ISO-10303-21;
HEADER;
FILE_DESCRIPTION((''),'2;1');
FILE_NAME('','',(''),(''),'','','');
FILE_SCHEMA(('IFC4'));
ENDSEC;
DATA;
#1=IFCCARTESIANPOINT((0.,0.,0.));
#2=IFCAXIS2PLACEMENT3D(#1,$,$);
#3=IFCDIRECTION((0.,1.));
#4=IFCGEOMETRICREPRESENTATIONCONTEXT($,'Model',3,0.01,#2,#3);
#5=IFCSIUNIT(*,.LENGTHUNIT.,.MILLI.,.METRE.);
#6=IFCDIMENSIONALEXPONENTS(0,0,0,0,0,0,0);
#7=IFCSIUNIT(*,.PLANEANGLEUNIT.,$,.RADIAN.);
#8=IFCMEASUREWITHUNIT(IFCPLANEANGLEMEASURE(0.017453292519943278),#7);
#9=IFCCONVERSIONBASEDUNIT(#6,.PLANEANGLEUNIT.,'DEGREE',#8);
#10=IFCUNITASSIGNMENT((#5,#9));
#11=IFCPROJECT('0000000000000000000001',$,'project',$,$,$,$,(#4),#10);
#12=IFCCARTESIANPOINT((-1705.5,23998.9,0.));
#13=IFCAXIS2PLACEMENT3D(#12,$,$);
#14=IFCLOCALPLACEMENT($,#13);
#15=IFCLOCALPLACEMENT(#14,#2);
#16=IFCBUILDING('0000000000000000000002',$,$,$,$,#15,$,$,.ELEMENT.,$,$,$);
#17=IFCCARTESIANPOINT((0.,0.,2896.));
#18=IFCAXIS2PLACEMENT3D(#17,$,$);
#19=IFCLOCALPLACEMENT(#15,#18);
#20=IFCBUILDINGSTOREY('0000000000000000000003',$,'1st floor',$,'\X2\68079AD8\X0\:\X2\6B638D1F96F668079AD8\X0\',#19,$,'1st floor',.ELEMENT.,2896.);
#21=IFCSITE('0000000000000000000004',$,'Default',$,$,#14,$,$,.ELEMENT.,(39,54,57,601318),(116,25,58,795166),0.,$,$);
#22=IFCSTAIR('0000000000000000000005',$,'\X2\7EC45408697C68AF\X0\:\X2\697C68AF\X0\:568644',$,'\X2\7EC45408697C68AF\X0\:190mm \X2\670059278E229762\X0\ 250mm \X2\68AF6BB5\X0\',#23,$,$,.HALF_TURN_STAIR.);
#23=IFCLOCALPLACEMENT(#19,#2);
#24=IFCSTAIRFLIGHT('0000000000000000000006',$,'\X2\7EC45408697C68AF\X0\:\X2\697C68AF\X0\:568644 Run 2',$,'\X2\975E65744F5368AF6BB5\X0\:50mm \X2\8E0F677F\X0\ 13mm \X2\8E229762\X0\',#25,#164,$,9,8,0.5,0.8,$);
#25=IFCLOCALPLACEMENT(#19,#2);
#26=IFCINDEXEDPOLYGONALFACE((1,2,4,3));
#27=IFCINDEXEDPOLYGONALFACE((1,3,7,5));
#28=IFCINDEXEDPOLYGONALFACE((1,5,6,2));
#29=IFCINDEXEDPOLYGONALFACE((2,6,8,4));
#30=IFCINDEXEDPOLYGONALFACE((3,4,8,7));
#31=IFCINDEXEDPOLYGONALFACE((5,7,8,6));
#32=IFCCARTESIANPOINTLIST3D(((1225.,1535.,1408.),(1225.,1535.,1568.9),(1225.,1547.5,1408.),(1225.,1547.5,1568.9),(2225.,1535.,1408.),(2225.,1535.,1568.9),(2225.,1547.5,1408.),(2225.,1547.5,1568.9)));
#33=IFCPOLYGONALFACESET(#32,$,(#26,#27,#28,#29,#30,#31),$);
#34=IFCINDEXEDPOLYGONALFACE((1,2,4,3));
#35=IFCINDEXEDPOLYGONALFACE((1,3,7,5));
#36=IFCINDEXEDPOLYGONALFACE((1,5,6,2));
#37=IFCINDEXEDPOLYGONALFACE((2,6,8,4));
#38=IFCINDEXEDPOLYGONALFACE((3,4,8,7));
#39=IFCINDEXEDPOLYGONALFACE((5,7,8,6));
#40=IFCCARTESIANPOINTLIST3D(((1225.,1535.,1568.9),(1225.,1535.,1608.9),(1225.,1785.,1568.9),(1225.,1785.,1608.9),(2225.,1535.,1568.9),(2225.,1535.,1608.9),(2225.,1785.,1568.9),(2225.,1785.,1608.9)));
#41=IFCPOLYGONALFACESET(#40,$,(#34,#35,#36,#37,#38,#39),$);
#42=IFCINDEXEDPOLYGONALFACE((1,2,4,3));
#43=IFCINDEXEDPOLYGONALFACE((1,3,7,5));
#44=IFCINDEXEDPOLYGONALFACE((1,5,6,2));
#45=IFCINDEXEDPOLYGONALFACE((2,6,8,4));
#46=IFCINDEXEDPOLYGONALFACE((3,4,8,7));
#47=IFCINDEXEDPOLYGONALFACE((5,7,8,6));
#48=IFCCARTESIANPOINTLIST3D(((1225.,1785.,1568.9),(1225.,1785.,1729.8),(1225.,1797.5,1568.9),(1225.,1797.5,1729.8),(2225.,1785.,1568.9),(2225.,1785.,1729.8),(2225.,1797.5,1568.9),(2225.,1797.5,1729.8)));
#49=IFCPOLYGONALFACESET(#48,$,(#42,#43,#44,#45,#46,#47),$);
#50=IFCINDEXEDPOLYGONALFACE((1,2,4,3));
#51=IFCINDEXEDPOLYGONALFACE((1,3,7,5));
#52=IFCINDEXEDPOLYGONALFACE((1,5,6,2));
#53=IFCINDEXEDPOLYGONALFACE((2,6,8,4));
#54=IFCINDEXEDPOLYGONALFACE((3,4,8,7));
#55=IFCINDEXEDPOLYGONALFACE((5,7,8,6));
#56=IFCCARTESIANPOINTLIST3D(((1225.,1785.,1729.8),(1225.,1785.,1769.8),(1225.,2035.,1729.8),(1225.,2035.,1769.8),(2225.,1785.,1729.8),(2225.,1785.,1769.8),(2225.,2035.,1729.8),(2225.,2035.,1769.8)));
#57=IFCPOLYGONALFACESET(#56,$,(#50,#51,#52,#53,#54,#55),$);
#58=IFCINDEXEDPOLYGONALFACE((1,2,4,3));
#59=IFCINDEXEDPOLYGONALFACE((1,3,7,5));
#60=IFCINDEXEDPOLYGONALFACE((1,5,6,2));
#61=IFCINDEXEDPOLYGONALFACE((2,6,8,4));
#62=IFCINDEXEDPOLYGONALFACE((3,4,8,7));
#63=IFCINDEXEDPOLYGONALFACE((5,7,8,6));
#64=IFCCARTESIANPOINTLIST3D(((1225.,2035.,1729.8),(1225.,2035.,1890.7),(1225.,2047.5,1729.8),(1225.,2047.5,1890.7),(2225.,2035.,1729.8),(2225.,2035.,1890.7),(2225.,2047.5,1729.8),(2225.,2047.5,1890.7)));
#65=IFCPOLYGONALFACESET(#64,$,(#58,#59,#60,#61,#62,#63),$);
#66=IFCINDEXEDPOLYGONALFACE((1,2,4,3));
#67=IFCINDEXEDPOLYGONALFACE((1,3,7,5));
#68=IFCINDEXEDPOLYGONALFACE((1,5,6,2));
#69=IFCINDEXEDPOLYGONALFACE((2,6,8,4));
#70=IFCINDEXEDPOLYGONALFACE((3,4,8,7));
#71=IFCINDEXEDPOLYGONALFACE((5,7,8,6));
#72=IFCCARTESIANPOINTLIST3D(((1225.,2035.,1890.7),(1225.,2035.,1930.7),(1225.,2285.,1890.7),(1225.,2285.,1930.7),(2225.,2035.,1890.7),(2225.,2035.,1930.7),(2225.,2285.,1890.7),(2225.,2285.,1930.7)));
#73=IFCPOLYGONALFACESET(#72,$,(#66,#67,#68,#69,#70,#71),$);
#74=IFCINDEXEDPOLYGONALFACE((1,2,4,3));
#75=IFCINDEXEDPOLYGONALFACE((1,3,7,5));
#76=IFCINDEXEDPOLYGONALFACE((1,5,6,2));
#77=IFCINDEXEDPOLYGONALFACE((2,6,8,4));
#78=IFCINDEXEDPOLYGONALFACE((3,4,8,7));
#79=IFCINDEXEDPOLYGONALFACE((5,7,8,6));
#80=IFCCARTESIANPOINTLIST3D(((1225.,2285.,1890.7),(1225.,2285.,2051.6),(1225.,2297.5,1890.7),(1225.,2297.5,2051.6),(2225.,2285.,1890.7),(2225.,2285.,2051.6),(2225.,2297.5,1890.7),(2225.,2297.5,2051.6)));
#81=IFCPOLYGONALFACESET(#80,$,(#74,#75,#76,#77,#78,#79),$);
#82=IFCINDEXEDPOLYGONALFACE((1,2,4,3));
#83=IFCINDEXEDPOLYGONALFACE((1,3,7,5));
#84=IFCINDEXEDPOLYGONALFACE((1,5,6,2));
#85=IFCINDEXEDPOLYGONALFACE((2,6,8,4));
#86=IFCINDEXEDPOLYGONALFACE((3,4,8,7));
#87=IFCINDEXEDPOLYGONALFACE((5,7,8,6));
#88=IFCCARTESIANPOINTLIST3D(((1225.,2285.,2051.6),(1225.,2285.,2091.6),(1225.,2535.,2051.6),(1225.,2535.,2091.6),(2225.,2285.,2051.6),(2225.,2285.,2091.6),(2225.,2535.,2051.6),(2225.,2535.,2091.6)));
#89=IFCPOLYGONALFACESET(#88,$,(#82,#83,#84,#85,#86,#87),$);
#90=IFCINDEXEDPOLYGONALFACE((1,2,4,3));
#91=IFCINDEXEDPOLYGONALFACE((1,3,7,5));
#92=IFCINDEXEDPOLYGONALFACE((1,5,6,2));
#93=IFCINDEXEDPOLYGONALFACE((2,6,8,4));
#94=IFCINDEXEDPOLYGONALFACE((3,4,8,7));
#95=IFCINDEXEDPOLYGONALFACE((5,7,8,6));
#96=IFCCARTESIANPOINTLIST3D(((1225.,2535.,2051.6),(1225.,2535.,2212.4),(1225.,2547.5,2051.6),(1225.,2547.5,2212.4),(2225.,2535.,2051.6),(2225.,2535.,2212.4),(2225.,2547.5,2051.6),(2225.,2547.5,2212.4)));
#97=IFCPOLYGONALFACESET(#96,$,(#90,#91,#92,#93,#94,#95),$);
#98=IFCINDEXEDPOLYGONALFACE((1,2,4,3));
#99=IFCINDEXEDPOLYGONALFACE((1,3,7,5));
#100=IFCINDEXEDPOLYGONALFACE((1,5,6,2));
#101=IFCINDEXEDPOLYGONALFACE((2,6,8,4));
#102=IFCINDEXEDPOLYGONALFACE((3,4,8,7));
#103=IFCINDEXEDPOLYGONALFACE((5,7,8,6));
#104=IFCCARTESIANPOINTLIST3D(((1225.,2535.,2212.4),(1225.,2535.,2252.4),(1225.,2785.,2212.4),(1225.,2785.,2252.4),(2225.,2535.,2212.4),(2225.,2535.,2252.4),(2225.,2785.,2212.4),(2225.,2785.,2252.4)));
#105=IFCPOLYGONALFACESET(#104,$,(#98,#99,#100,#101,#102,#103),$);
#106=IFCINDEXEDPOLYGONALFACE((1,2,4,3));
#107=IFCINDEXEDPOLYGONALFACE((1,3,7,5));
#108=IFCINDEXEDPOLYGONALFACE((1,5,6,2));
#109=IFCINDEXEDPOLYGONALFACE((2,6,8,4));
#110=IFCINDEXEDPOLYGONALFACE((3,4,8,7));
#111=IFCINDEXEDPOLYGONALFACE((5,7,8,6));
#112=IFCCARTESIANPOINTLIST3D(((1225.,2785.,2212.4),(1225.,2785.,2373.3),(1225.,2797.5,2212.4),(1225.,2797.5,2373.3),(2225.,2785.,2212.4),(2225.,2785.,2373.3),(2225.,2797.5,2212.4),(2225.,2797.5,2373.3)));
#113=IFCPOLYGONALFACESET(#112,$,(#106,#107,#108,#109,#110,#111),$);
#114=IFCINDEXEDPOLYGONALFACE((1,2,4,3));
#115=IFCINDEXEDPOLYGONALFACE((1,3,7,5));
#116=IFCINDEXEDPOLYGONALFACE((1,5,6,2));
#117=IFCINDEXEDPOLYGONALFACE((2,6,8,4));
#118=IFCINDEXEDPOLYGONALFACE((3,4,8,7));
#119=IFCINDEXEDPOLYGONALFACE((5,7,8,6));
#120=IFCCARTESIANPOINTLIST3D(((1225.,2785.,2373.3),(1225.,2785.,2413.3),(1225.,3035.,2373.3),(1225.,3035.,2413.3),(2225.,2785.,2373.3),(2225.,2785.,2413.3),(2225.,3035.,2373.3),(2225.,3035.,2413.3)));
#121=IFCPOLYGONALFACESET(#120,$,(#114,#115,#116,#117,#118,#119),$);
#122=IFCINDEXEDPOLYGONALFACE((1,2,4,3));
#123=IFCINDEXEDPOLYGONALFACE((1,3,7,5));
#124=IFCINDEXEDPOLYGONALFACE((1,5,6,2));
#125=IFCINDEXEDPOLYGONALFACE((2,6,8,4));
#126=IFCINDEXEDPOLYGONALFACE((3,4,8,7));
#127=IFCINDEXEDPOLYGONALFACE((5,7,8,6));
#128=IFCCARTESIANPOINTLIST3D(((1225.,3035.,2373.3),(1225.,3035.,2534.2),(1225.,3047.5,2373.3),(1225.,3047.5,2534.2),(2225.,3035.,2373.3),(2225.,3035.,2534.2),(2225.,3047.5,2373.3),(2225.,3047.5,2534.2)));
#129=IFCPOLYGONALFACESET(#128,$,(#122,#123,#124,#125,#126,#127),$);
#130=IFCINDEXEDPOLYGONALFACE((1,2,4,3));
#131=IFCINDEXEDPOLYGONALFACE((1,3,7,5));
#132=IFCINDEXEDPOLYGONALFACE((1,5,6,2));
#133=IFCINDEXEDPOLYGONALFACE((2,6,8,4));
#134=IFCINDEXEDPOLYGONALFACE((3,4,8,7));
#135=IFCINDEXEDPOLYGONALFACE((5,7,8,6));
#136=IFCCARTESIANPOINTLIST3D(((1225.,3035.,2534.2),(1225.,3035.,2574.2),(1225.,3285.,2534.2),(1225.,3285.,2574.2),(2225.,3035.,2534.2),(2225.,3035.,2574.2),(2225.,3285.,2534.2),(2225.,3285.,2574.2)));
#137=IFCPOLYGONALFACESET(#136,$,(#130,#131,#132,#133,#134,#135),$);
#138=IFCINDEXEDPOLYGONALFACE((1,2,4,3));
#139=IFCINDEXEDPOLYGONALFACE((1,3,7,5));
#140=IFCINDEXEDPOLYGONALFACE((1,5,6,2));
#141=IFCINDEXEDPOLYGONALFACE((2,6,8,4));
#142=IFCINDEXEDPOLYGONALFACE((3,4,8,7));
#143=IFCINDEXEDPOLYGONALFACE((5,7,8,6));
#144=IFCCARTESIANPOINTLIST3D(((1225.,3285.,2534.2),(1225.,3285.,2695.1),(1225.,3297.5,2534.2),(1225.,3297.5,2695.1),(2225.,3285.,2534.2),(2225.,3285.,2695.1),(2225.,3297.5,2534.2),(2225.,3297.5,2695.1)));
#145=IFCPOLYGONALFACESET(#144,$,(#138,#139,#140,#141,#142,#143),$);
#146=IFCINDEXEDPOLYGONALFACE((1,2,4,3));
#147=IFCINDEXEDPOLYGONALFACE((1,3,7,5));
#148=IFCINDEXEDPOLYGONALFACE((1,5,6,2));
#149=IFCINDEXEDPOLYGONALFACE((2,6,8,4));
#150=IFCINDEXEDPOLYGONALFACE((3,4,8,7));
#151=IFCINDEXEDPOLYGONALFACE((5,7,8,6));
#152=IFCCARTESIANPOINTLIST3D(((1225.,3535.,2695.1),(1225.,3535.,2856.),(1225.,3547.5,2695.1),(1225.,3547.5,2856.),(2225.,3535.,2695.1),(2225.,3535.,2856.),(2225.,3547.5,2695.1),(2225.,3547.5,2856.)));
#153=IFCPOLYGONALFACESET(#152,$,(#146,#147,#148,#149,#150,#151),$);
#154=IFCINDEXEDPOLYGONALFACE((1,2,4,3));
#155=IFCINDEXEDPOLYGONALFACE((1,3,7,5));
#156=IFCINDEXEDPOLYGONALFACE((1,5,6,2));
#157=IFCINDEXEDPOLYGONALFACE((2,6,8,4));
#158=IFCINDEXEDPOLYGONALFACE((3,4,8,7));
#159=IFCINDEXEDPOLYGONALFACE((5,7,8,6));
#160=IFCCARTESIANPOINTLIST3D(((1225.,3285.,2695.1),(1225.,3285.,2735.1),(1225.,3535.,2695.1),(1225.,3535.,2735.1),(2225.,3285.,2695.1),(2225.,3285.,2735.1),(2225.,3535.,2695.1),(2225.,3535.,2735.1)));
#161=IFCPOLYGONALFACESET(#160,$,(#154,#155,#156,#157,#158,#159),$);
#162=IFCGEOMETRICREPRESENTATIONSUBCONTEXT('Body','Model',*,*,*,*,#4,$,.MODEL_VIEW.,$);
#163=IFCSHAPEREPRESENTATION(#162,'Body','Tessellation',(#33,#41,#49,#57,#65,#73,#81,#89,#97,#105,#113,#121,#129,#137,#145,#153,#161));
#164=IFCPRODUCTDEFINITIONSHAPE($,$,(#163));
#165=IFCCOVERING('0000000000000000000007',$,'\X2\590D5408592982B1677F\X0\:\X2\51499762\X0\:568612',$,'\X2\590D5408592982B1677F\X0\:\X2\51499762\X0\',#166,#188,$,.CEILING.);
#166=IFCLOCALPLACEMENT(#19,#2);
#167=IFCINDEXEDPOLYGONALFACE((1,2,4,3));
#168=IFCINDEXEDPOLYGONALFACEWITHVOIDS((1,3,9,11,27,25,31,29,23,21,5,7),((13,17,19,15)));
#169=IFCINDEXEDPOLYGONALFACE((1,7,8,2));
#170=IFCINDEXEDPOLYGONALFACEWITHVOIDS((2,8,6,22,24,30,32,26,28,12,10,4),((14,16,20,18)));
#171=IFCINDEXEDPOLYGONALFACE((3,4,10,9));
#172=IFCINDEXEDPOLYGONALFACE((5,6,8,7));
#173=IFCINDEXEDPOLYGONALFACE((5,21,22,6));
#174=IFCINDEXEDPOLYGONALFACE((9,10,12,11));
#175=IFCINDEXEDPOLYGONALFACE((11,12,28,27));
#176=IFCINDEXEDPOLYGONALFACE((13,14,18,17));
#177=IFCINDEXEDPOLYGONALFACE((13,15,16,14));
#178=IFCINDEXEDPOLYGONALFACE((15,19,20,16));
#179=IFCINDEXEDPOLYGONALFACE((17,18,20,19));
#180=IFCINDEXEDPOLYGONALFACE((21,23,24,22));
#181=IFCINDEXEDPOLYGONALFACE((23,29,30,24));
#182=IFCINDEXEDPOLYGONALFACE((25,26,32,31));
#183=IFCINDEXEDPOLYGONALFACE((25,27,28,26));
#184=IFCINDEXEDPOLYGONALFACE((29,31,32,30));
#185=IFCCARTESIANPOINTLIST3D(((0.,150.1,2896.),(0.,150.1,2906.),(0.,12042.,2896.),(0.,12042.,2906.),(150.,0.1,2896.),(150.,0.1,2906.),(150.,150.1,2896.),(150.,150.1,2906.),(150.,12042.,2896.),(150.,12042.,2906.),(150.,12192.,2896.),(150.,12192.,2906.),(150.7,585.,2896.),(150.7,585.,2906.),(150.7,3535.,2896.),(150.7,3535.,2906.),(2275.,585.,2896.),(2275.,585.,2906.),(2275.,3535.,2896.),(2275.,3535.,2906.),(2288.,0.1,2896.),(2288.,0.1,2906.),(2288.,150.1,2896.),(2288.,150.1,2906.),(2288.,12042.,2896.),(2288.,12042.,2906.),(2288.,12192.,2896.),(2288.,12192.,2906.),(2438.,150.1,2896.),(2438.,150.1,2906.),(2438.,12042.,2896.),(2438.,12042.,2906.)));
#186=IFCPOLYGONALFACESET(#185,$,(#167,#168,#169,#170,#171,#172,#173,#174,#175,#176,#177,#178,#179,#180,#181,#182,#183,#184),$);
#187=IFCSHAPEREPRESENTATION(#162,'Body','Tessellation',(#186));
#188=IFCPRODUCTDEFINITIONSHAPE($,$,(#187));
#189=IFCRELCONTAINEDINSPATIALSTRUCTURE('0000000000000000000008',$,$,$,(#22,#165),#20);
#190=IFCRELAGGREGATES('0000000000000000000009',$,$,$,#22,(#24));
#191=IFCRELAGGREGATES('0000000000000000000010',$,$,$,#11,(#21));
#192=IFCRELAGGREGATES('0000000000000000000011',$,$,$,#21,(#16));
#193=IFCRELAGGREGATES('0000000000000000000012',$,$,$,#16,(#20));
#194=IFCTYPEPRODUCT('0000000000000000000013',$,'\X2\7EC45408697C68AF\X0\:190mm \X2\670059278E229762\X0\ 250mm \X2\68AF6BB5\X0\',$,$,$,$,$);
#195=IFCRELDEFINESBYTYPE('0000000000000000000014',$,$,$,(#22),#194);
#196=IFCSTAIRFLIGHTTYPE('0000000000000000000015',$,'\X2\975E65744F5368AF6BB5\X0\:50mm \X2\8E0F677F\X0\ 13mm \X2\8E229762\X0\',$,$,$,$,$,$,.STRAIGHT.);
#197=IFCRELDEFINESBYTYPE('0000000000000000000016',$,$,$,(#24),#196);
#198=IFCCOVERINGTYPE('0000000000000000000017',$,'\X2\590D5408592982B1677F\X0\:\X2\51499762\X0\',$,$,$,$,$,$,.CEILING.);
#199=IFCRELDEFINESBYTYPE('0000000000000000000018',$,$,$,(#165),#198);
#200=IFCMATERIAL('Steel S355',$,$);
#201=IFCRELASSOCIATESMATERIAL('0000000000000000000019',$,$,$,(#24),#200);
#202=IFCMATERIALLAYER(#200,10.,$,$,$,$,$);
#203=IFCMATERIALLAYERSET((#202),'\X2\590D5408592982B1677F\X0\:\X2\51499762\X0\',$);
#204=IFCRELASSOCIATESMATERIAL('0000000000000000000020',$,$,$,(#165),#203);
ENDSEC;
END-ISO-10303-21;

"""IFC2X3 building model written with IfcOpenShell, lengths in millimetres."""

from ifc_helpers import new_model, entity, si_unit, converted_unit, direction, frame, frame_2d, origin, origin_2d_with_axis, place, context, subcontext, project, spatial, polyline, rectangle, outline, extrude, material, layer, layer_set, layer_usage, type_object, element, aggregate, save


model = new_model("IFC2X3")

# Units and contexts
model_context = context("Model", 3, precision=0.01, world=origin(), true_north=direction((0.0, 1.0)))
body_context = subcontext(model_context, "Body", "Model", "MODEL_VIEW")
ifc_project = project(units=[si_unit("LENGTHUNIT", "METRE", prefix="MILLI"), converted_unit("PLANEANGLEUNIT", "DEGREE", entity("IfcPlaneAngleMeasure", 0.017453292519943278), si_unit("PLANEANGLEUNIT", "RADIAN"), dimensions=[0, 0, 0, 0, 0, 0, 0])], contexts=[model_context])

# Site, building, storey
site_placement = place(None, frame((-1705.5, 23998.9, 0.0)))
site = spatial("IfcSite", under=ifc_project, at=site_placement, Name="Default", CompositionType="ELEMENT", RefLatitude=(39, 54, 57, 601318), RefLongitude=(116, 25, 58, 795166), RefElevation=0.0)
building_placement = place(site_placement, origin())
building = spatial("IfcBuilding", under=site, at=building_placement, CompositionType="ELEMENT")
storey_placement = place(building_placement, frame((0.0, 0.0, 2896.0)))
storey = spatial("IfcBuildingStorey", under=building, at=storey_placement, Name="1st floor", ObjectType="标高:正负零标高", LongName="1st floor", CompositionType="ELEMENT", Elevation=2896.0)

# Stair
type_product = type_object("IfcTypeProduct", Name="组合楼梯:190mm 最大踢面 250mm 梯段")
stair_placement = place(storey_placement, origin())
stair = element("IfcStair", 1, at=stair_placement, inside=storey, type_object=type_product, Name="组合楼梯:楼梯:568644", ObjectType="组合楼梯:190mm 最大踢面 250mm 梯段", ShapeType="HALF_TURN_STAIR")
ifc_material_1 = material(Name="Steel S355")

# Stair flight
stair_flight_type = type_object("IfcStairFlightType", Name="非整体梯段:50mm 踏板 13mm 踢面", PredefinedType="STRAIGHT")
stair_flight_1_placement = place(stair_placement, origin())
stair_flight_1 = element("IfcStairFlight", 2, at=stair_flight_1_placement, type_object=stair_flight_type, material=ifc_material_1, Name="组合楼梯:楼梯:568644 Run 2", ObjectType="非整体梯段:50mm 踏板 13mm 踢面", NumberOfRiser=9, NumberOfTreads=8, RiserHeight=0.5, TreadLength=0.8, context=body_context, shape_type="SweptSolid", body=[
    extrude(rectangle(XDim=1000.0, YDim=12.5, at=origin_2d_with_axis()), frame((1725.0, 1541.2, 1408.0), z_axis=(0.0, 0.0, 1.0), x_axis=(-1.0, 0.0, 0.0)), (0.0, 0.0, 1.0), 160.9),
    extrude(rectangle(XDim=250.0, YDim=1000.0, at=frame_2d((0.0, 0.0), x_axis=(1.0, 0.0))), frame((1725.0, 1660.0, 1568.9), z_axis=(0.0, 0.0, 1.0), x_axis=(0.0, -1.0, 0.0)), (0.0, 0.0, 1.0), 40.0),
    extrude(rectangle(XDim=1000.0, YDim=12.5, at=origin_2d_with_axis()), frame((1725.0, 1791.2, 1568.9), z_axis=(0.0, 0.0, 1.0), x_axis=(-1.0, 0.0, 0.0)), (0.0, 0.0, 1.0), 160.9),
    extrude(rectangle(XDim=250.0, YDim=1000.0, at=frame_2d((0.0, 0.0), x_axis=(1.0, 0.0))), frame((1725.0, 1910.0, 1729.8), z_axis=(0.0, 0.0, 1.0), x_axis=(0.0, -1.0, 0.0)), (0.0, 0.0, 1.0), 40.0),
    extrude(rectangle(XDim=1000.0, YDim=12.5, at=origin_2d_with_axis()), frame((1725.0, 2041.2, 1729.8), z_axis=(0.0, 0.0, 1.0), x_axis=(-1.0, 0.0, 0.0)), (0.0, 0.0, 1.0), 160.9),
    extrude(rectangle(XDim=250.0, YDim=1000.0, at=frame_2d((0.0, 0.0), x_axis=(1.0, 0.0))), frame((1725.0, 2160.0, 1890.7), z_axis=(0.0, 0.0, 1.0), x_axis=(0.0, -1.0, 0.0)), (0.0, 0.0, 1.0), 40.0),
    extrude(rectangle(XDim=1000.0, YDim=12.5, at=origin_2d_with_axis()), frame((1725.0, 2291.2, 1890.7), z_axis=(0.0, 0.0, 1.0), x_axis=(-1.0, 0.0, 0.0)), (0.0, 0.0, 1.0), 160.9),
    extrude(rectangle(XDim=250.0, YDim=1000.0, at=frame_2d((0.0, 0.0), x_axis=(1.0, 0.0))), frame((1725.0, 2410.0, 2051.6), z_axis=(0.0, 0.0, 1.0), x_axis=(0.0, -1.0, 0.0)), (0.0, 0.0, 1.0), 40.0),
    extrude(rectangle(XDim=1000.0, YDim=12.5, at=origin_2d_with_axis()), frame((1725.0, 2541.2, 2051.6), z_axis=(0.0, 0.0, 1.0), x_axis=(-1.0, 0.0, 0.0)), (0.0, 0.0, 1.0), 160.9),
    extrude(rectangle(XDim=250.0, YDim=1000.0, at=origin_2d_with_axis()), frame((1725.0, 2660.0, 2212.4), z_axis=(0.0, 0.0, 1.0), x_axis=(0.0, -1.0, 0.0)), (0.0, 0.0, 1.0), 40.0),
    extrude(rectangle(XDim=1000.0, YDim=12.5, at=frame_2d((0.0, 0.0), x_axis=(1.0, 0.0))), frame((1725.0, 2791.2, 2212.4), z_axis=(0.0, 0.0, 1.0), x_axis=(-1.0, 0.0, 0.0)), (0.0, 0.0, 1.0), 160.9),
    extrude(rectangle(XDim=250.0, YDim=1000.0, at=origin_2d_with_axis()), frame((1725.0, 2910.0, 2373.3), z_axis=(0.0, 0.0, 1.0), x_axis=(0.0, -1.0, 0.0)), (0.0, 0.0, 1.0), 40.0),
    extrude(rectangle(XDim=1000.0, YDim=12.5, at=frame_2d((0.0, 0.0), x_axis=(1.0, 0.0))), frame((1725.0, 3041.2, 2373.3), z_axis=(0.0, 0.0, 1.0), x_axis=(-1.0, 0.0, 0.0)), (0.0, 0.0, 1.0), 160.9),
    extrude(rectangle(XDim=250.0, YDim=1000.0, at=frame_2d((0.0, 0.0), x_axis=(1.0, 0.0))), frame((1725.0, 3160.0, 2534.2), z_axis=(0.0, 0.0, 1.0), x_axis=(0.0, -1.0, 0.0)), (0.0, 0.0, 1.0), 40.0),
    extrude(rectangle(XDim=1000.0, YDim=12.5, at=origin_2d_with_axis()), frame((1725.0, 3291.2, 2534.2), z_axis=(0.0, 0.0, 1.0), x_axis=(-1.0, 0.0, 0.0)), (0.0, 0.0, 1.0), 160.9),
    extrude(rectangle(XDim=1000.0, YDim=12.5, at=frame_2d((0.0, 0.0), x_axis=(1.0, 0.0))), frame((1725.0, 3541.2, 2695.1), z_axis=(0.0, 0.0, 1.0), x_axis=(-1.0, 0.0, 0.0)), (0.0, 0.0, 1.0), 160.9),
    extrude(rectangle(XDim=250.0, YDim=1000.0, at=origin_2d_with_axis()), frame((1725.0, 3410.0, 2695.1), z_axis=(0.0, 0.0, 1.0), x_axis=(0.0, -1.0, 0.0)), (0.0, 0.0, 1.0), 40.0),
])
aggregate(stair, [stair_flight_1])

# Covering
ifc_layer_1 = layer(ifc_material_1, 10.0)
ifc_layer_set_1 = layer_set([ifc_layer_1], Name="复合天花板:光面")
ifc_layer_usage_1 = layer_usage(ifc_layer_set_1, "AXIS3", "NEGATIVE", 10.0)
covering_type = type_object("IfcCoveringType", Name="复合天花板:光面", PredefinedType="CEILING")
covering_placement = place(storey_placement, origin())
element("IfcCovering", 3, at=covering_placement, inside=storey, type_object=covering_type, material=ifc_layer_usage_1, Name="复合天花板:光面:568612", ObjectType="复合天花板:光面", PredefinedType="CEILING", context=body_context, shape_type="SweptSolid", body=[
    extrude(outline(polyline([(5946.0, -1069.0), (6096.0, -1069.0), (6096.0, 1069.0), (5945.9, 1069.0), (5945.9, 1219.0), (-5946.0, 1219.0), (-5946.0, 1069.0), (-6096.0, 1069.0), (-6096.0, -1069.0), (-5946.0, -1069.0), (-5946.0, -1219.0), (5946.0, -1219.0), (5946.0, -1069.0)]), holes=[polyline([(-2561.0, 1068.3), (-2561.0, -1056.0), (-5511.0, -1056.0), (-5511.0, 1068.3), (-2561.0, 1068.3)])]), frame((1219.0, 6096.0, 2896.0), z_axis=(0.0, 0.0, 1.0), x_axis=(0.0, 1.0, 0.0)), (0.0, 0.0, 1.0), 10.0),
])

save(model, "model.ifc")
